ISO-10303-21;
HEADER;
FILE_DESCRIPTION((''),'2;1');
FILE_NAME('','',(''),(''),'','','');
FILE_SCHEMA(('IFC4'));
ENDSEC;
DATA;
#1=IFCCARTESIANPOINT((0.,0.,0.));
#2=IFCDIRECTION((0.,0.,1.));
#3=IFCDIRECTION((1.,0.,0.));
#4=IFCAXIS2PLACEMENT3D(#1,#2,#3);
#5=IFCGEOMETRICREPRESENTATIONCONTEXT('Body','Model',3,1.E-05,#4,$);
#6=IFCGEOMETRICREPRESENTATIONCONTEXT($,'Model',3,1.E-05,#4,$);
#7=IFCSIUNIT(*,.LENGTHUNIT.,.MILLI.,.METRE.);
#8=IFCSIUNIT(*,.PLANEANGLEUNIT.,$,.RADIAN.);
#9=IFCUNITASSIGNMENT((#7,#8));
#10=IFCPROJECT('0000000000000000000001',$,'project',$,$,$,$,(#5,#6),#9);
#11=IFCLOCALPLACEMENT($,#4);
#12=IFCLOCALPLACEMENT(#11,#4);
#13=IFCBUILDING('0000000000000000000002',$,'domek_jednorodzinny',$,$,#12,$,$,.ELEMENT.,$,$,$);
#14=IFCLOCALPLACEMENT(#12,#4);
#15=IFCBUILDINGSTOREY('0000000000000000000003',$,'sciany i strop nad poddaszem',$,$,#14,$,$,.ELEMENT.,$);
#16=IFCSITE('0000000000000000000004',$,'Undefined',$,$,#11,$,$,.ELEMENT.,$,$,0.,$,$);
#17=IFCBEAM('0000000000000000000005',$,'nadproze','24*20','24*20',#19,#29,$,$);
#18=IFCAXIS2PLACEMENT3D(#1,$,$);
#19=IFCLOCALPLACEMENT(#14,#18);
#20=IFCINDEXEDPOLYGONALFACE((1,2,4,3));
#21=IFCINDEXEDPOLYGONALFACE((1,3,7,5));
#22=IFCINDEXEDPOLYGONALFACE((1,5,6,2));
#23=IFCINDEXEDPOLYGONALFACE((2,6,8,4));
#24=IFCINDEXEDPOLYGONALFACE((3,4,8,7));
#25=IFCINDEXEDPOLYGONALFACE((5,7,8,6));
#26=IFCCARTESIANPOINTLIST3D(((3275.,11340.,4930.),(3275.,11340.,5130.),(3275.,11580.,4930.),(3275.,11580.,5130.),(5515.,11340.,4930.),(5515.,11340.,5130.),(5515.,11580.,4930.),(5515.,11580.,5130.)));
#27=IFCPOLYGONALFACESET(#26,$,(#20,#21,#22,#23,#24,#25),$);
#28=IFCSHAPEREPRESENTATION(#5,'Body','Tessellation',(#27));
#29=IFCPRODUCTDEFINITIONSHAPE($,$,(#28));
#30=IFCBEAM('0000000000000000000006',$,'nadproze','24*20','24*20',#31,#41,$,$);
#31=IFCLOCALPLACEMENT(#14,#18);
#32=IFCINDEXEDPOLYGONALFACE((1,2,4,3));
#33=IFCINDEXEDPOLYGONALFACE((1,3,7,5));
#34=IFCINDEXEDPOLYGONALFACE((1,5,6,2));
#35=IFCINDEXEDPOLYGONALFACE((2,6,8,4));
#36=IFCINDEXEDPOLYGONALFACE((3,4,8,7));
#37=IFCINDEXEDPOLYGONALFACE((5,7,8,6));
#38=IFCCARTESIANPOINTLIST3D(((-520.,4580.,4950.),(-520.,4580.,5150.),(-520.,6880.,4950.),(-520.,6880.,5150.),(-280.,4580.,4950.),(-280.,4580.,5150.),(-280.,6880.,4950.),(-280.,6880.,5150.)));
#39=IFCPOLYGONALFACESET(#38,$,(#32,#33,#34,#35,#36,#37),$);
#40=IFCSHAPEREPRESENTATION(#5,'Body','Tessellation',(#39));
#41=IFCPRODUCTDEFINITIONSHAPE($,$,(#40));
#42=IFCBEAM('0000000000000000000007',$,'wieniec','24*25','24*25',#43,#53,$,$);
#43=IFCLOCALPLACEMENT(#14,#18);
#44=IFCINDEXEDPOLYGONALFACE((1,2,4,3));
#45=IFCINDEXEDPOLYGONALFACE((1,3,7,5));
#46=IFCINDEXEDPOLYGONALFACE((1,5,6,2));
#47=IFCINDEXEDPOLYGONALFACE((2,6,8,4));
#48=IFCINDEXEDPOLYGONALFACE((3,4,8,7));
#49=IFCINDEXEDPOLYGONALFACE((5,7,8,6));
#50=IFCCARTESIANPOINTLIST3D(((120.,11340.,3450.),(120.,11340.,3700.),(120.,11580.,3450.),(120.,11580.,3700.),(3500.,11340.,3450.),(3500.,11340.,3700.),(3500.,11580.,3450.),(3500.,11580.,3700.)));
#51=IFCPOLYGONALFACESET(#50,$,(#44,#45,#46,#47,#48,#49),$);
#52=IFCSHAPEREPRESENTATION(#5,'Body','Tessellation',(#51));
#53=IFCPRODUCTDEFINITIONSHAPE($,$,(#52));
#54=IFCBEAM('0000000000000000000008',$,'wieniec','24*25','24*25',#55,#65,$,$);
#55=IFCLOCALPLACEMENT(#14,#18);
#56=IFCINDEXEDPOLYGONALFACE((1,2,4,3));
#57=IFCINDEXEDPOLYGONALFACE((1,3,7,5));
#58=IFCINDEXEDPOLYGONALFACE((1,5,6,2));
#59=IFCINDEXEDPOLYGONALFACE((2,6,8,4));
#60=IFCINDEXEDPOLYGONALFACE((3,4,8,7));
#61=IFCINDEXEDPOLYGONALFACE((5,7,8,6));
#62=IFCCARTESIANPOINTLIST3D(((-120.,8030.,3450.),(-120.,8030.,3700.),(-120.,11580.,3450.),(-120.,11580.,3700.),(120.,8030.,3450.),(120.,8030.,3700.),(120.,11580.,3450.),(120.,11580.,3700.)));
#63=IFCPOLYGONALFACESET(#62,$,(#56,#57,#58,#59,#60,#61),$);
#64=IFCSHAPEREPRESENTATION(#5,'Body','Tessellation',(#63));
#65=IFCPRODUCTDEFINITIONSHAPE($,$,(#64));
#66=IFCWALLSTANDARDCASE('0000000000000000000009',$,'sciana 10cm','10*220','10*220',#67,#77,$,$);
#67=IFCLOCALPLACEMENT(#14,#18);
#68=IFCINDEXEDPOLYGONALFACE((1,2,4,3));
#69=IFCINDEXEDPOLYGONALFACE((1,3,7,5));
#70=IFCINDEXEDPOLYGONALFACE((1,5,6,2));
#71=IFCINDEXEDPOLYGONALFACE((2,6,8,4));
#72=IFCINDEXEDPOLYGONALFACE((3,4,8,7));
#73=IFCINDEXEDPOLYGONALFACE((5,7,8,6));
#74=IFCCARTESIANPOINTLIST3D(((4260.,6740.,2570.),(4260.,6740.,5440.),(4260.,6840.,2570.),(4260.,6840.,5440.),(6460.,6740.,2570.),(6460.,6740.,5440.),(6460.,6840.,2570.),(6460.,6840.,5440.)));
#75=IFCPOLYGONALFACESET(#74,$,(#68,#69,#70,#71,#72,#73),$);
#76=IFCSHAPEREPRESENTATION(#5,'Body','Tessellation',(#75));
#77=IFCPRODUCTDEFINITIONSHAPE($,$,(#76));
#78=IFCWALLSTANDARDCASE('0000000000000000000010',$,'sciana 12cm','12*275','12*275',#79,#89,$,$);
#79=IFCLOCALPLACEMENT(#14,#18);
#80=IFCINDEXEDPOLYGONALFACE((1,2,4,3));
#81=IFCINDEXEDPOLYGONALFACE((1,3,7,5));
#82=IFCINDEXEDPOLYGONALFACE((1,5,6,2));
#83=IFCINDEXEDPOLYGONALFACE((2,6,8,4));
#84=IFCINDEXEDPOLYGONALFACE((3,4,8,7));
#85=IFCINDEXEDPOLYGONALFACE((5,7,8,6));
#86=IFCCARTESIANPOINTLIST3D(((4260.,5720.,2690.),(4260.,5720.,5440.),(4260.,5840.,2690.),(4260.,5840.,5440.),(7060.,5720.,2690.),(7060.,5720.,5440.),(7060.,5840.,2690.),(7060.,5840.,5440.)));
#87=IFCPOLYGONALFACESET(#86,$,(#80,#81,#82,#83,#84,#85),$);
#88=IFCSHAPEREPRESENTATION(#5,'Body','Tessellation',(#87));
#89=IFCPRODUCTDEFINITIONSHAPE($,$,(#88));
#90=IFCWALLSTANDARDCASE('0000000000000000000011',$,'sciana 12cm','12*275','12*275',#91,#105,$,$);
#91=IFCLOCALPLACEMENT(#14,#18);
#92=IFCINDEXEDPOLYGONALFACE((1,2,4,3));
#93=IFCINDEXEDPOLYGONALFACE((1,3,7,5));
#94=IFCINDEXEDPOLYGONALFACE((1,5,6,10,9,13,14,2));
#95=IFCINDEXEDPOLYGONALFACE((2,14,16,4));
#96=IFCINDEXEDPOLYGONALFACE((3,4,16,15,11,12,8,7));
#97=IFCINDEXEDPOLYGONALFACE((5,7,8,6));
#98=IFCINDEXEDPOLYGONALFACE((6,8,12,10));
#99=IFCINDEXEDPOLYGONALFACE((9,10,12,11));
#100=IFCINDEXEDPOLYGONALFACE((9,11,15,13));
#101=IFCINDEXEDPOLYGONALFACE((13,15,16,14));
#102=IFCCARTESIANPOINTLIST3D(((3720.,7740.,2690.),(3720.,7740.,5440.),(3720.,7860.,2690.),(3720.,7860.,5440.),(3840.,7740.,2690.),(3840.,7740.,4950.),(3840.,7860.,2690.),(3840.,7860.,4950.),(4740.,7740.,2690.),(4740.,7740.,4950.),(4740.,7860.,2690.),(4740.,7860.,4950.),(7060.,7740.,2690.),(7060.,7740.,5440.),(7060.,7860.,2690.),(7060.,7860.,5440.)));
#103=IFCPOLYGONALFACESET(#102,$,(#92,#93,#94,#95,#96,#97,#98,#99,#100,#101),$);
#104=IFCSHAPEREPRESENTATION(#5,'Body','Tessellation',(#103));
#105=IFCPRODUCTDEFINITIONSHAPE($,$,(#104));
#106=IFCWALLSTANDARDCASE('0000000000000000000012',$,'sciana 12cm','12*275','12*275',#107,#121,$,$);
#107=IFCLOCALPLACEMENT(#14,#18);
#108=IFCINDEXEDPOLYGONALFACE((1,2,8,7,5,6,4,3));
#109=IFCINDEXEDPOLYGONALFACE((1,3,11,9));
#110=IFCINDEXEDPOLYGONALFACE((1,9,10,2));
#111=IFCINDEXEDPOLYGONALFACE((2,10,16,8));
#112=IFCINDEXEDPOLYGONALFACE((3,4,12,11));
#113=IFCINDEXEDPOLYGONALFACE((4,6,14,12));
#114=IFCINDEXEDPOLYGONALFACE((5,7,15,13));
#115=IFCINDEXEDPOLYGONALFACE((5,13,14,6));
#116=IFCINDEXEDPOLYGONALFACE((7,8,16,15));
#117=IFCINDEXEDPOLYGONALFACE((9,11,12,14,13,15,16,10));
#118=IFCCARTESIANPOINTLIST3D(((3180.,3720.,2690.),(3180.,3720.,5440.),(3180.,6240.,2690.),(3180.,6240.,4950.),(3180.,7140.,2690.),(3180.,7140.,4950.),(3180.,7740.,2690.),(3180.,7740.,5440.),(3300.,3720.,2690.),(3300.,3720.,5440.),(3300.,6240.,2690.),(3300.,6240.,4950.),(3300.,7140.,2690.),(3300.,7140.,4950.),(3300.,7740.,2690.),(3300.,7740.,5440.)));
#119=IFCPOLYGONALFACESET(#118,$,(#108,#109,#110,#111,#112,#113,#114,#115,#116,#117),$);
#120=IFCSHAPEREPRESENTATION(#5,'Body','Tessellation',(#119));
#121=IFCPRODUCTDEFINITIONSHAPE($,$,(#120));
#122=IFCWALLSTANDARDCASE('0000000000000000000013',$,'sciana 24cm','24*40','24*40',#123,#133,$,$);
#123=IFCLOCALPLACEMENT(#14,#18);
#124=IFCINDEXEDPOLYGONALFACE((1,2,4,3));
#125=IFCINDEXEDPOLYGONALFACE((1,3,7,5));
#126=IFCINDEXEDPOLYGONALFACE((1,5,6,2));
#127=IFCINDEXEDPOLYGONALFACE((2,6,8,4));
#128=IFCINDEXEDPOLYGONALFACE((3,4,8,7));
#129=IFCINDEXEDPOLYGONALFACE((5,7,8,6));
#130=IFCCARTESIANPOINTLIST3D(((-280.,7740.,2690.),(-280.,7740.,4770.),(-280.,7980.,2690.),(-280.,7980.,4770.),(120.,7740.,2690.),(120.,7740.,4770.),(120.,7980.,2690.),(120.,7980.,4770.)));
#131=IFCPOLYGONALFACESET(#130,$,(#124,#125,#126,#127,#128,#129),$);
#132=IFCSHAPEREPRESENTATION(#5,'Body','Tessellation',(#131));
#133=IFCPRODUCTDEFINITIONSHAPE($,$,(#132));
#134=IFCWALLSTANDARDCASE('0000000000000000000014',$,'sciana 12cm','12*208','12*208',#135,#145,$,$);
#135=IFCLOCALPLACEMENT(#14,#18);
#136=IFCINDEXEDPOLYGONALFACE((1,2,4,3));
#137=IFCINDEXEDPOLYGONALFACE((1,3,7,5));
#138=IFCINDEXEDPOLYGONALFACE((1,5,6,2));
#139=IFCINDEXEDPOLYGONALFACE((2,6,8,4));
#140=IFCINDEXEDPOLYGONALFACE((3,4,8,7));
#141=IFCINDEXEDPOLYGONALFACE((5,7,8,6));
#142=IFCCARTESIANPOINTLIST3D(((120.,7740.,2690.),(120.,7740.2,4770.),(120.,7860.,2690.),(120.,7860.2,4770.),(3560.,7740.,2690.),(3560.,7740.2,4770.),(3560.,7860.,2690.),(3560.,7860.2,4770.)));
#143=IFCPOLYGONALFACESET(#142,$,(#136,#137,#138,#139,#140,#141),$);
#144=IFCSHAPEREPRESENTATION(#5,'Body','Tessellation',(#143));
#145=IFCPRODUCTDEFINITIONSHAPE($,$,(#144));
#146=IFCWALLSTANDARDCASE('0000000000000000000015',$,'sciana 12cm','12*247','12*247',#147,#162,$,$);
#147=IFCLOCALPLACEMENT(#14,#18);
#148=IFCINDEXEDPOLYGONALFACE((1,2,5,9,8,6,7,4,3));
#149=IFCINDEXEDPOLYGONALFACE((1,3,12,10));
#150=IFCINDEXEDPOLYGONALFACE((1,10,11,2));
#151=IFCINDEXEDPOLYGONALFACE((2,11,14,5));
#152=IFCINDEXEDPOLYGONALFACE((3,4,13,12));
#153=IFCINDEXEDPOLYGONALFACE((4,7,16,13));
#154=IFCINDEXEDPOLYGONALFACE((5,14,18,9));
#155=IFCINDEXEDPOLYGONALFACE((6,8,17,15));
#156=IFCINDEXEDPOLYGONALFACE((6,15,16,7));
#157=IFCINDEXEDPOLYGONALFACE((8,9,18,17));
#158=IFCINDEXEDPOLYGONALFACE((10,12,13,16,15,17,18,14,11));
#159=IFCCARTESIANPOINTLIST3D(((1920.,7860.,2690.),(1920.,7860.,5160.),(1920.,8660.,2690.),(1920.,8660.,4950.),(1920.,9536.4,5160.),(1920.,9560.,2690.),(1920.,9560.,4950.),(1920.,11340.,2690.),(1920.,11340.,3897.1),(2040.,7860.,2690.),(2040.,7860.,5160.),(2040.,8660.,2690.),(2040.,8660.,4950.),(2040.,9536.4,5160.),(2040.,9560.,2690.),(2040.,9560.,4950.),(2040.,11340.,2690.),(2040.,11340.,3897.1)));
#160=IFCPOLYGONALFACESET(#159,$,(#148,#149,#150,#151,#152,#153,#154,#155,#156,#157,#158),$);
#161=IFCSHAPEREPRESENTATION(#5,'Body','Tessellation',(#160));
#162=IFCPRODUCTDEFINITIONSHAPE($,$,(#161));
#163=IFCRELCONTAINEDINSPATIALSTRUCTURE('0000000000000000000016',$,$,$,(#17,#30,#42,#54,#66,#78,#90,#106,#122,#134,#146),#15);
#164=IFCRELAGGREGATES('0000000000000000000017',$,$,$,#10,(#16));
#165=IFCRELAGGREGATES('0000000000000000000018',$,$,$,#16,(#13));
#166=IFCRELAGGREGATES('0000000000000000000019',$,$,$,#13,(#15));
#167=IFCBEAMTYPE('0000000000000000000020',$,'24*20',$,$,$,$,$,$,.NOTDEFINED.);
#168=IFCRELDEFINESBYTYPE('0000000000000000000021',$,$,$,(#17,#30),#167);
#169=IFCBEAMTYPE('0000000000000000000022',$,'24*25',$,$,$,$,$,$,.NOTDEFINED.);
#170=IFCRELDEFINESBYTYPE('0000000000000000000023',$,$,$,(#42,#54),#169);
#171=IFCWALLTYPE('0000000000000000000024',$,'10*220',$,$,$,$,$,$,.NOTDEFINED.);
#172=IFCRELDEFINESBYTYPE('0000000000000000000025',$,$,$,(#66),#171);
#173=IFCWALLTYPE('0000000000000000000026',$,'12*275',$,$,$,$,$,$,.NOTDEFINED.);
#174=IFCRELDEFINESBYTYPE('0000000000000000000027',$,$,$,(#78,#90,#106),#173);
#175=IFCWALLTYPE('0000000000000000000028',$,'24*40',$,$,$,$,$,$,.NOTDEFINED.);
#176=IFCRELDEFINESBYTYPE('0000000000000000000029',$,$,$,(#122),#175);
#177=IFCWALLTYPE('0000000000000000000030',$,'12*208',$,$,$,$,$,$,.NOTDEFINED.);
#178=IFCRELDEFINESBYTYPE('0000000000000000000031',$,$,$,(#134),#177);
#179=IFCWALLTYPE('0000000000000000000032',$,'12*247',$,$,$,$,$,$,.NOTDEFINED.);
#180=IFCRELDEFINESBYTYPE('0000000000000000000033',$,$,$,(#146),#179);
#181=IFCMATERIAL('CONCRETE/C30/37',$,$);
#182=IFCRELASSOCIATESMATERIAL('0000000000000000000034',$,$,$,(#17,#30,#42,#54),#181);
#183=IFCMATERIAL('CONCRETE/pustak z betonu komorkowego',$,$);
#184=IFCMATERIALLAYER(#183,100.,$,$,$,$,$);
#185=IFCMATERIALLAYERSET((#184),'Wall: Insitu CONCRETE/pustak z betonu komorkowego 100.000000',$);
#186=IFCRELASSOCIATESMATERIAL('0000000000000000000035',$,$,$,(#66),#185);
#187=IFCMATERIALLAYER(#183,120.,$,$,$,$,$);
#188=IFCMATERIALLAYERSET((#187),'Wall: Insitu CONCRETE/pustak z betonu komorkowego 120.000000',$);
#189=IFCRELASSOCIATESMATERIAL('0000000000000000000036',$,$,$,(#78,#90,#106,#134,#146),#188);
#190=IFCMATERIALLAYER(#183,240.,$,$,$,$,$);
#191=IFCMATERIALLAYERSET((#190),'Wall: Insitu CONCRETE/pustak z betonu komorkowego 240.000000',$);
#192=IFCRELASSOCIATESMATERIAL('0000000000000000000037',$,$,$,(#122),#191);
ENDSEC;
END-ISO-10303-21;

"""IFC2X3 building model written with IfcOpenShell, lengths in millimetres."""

from ifc_helpers import new_model, si_unit, frame, frame_2d, origin_with_axes, origin_2d_with_axis, place, context, project, spatial, polyline, rectangle, outline, extrude, clip, halfspace, material, layer, layer_set, layer_usage, type_object, element, save


model = new_model("IFC2X3")

# Units and contexts
model_context_1 = context("Model", 3, precision=1e-05, world=origin_with_axes(), identifier="Body")
model_context_2 = context("Model", 3, precision=1e-05, world=origin_with_axes())
ifc_project = project(units=[si_unit("LENGTHUNIT", "METRE", prefix="MILLI"), si_unit("PLANEANGLEUNIT", "RADIAN")], contexts=[model_context_1, model_context_2])

# Site, building, storey
site_placement = place(None, origin_with_axes())
site = spatial("IfcSite", under=ifc_project, at=site_placement, Name="Undefined", CompositionType="ELEMENT", RefElevation=0.0)
building_placement = place(site_placement, origin_with_axes())
building = spatial("IfcBuilding", under=site, at=building_placement, Name="domek_jednorodzinny", CompositionType="ELEMENT")
storey_placement = place(building_placement, origin_with_axes())
storey = spatial("IfcBuildingStorey", under=building, at=storey_placement, Name="sciany i strop nad poddaszem", CompositionType="ELEMENT")

# Beams
ifc_material_1 = material(Name="CONCRETE/C30/37")
beam_type_1 = type_object("IfcBeamType", Name="24*20", PredefinedType="NOTDEFINED")
beam_1_placement = place(storey_placement, frame((3275.0, 11460.0, 5030.0), z_axis=(0.0, 0.0, 1.0), x_axis=(1.0, 0.0, 0.0)))
element("IfcBeam", 1, at=beam_1_placement, inside=storey, type_object=beam_type_1, material=ifc_material_1, Name="nadproze", Description="24*20", ObjectType="24*20", context=model_context_1, shape_type="SweptSolid", body=[
    extrude(rectangle(XDim=240.0, YDim=200.0, at=origin_2d_with_axis()), frame((2240.0, 0.0, 0.0), z_axis=(-1.0, 0.0, 0.0), x_axis=(0.0, -1.0, 0.0)), (0.0, 0.0, 1.0), 2240.0),
])
beam_2_placement = place(storey_placement, frame((-400.0, 6880.0, 5050.0), z_axis=(0.0, 0.0, 1.0), x_axis=(0.0, -1.0, 0.0)))
element("IfcBeam", 2, at=beam_2_placement, inside=storey, type_object=beam_type_1, material=ifc_material_1, Name="nadproze", Description="24*20", ObjectType="24*20", context=model_context_1, shape_type="SweptSolid", body=[
    extrude(rectangle(XDim=240.0, YDim=200.0, at=origin_2d_with_axis()), frame((2300.0, 0.0, 0.0), z_axis=(-1.0, 0.0, 0.0), x_axis=(0.0, -1.0, 0.0)), (0.0, 0.0, 1.0), 2300.0),
])
beam_type_2 = type_object("IfcBeamType", Name="24*25", PredefinedType="NOTDEFINED")
beam_3_placement = place(storey_placement, frame((3500.0, 11460.0, 3575.0), z_axis=(0.0, 0.0, 1.0), x_axis=(-1.0, 0.0, 0.0)))
element("IfcBeam", 3, at=beam_3_placement, inside=storey, type_object=beam_type_2, material=ifc_material_1, Name="wieniec", Description="24*25", ObjectType="24*25", context=model_context_1, shape_type="SweptSolid", body=[
    extrude(rectangle(XDim=240.0, YDim=250.0, at=origin_2d_with_axis()), frame((3380.0, 0.0, 0.0), z_axis=(-1.0, 0.0, 0.0), x_axis=(0.0, -1.0, 0.0)), (0.0, 0.0, 1.0), 3380.0),
])
beam_4_placement = place(storey_placement, frame((0.0, 11580.0, 3575.0), z_axis=(0.0, 0.0, 1.0), x_axis=(0.0, -1.0, 0.0)))
element("IfcBeam", 4, at=beam_4_placement, inside=storey, type_object=beam_type_2, material=ifc_material_1, Name="wieniec", Description="24*25", ObjectType="24*25", context=model_context_1, shape_type="SweptSolid", body=[
    extrude(rectangle(XDim=240.0, YDim=250.0, at=origin_2d_with_axis()), frame((3550.0, 0.0, 0.0), z_axis=(-1.0, 0.0, 0.0), x_axis=(0.0, -1.0, 0.0)), (0.0, 0.0, 1.0), 3550.0),
])

# Walls
ifc_material_2 = material(Name="CONCRETE/pustak z betonu komorkowego")
ifc_layer_1 = layer(ifc_material_2, 100.0)
ifc_layer_set_1 = layer_set([ifc_layer_1], Name="Wall: Insitu CONCRETE/pustak z betonu komorkowego 100.000000")
ifc_layer_usage_1 = layer_usage(ifc_layer_set_1, "AXIS2", "POSITIVE", -50.0)
wall_type_1 = type_object("IfcWallType", Name="10*220", PredefinedType="NOTDEFINED")
wall_1_placement = place(storey_placement, frame((4260.0, 6790.0, 2570.0), z_axis=(0.0, 0.0, 1.0), x_axis=(1.0, 0.0, 0.0)))
element("IfcWallStandardCase", 5, at=wall_1_placement, inside=storey, type_object=wall_type_1, material=ifc_layer_usage_1, Name="sciana 10cm", Description="10*220", ObjectType="10*220", context=model_context_1, shape_type="SweptSolid", body=[
    extrude(rectangle(XDim=2200.0, YDim=100.0, at=frame_2d((0.0, 1100.0), x_axis=(0.0, -1.0))), frame((0.0, 0.0, 0.0), z_axis=(0.0, 0.0, 1.0), x_axis=(0.0, -1.0, 0.0)), (0.0, 0.0, 1.0), 2870.0),
])
ifc_layer_2 = layer(ifc_material_2, 120.0)
ifc_layer_set_2 = layer_set([ifc_layer_2], Name="Wall: Insitu CONCRETE/pustak z betonu komorkowego 120.000000")
ifc_layer_usage_2 = layer_usage(ifc_layer_set_2, "AXIS2", "POSITIVE", -60.0)
wall_type_2 = type_object("IfcWallType", Name="12*275", PredefinedType="NOTDEFINED")
wall_2_placement = place(storey_placement, frame((4260.0, 5780.0, 2690.0), z_axis=(0.0, 0.0, 1.0), x_axis=(1.0, 0.0, 0.0)))
element("IfcWallStandardCase", 6, at=wall_2_placement, inside=storey, type_object=wall_type_2, material=ifc_layer_usage_2, Name="sciana 12cm", Description="12*275", ObjectType="12*275", context=model_context_1, shape_type="SweptSolid", body=[
    extrude(rectangle(XDim=2800.0, YDim=120.0, at=frame_2d((0.0, 1400.0), x_axis=(0.0, -1.0))), frame((0.0, 0.0, 0.0), z_axis=(0.0, 0.0, 1.0), x_axis=(0.0, -1.0, 0.0)), (0.0, 0.0, 1.0), 2750.0),
])

# Walls, openings
ifc_layer_usage_3 = layer_usage(ifc_layer_set_2, "AXIS2", "POSITIVE", -60.0)
wall_3_placement = place(storey_placement, frame((3720.0, 7800.0, 2690.0), z_axis=(0.0, 0.0, 1.0), x_axis=(1.0, 0.0, 0.0)))
wall_3 = element("IfcWallStandardCase", 7, at=wall_3_placement, inside=storey, type_object=wall_type_2, material=ifc_layer_usage_3, Name="sciana 12cm", Description="12*275", ObjectType="12*275", context=model_context_1, shape_type="SweptSolid", body=[
    extrude(rectangle(XDim=3340.0, YDim=120.0, at=frame_2d((0.0, 1670.0), x_axis=(0.0, -1.0))), frame((0.0, 0.0, 0.0), z_axis=(0.0, 0.0, 1.0), x_axis=(0.0, -1.0, 0.0)), (0.0, 0.0, 1.0), 2750.0),
])
opening_1_placement = place(storey_placement, frame((3720.0, 7800.0, 2690.0), z_axis=(0.0, 0.0, 1.0), x_axis=(1.0, 0.0, 0.0)))
element("IfcOpeningElement", 8, at=opening_1_placement, cuts=wall_3, ObjectType="Recess", context=model_context_1, shape_type="SweptSolid", body=[
    extrude(outline(polyline([(0.0, 0.0), (520.0, 0.0), (520.0, 900.0), (0.0, 900.0), (0.0, 0.0)])), frame((1020.0, -260.0, 0.0), z_axis=(0.0, 0.0, 1.0), x_axis=(0.0, 1.0, 0.0)), (0.0, 0.0, 1.0), 2260.0),
])
ifc_layer_usage_4 = layer_usage(ifc_layer_set_2, "AXIS2", "POSITIVE", -60.0)
wall_4_placement = place(storey_placement, frame((3240.0, 3720.0, 2690.0), z_axis=(0.0, 0.0, 1.0), x_axis=(0.0, 1.0, 0.0)))
wall_4 = element("IfcWallStandardCase", 9, at=wall_4_placement, inside=storey, type_object=wall_type_2, material=ifc_layer_usage_4, Name="sciana 12cm", Description="12*275", ObjectType="12*275", context=model_context_1, shape_type="SweptSolid", body=[
    extrude(rectangle(XDim=4020.0, YDim=120.0, at=frame_2d((0.0, 2010.0), x_axis=(0.0, -1.0))), frame((0.0, 0.0, 0.0), z_axis=(0.0, 0.0, 1.0), x_axis=(0.0, -1.0, 0.0)), (0.0, 0.0, 1.0), 2750.0),
])
opening_2_placement = place(storey_placement, frame((3240.0, 3720.0, 2690.0), z_axis=(0.0, 0.0, 1.0), x_axis=(0.0, 1.0, 0.0)))
element("IfcOpeningElement", 10, at=opening_2_placement, cuts=wall_4, ObjectType="Recess", context=model_context_1, shape_type="SweptSolid", body=[
    extrude(outline(polyline([(0.0, 0.0), (520.0, 0.0), (520.0, 900.0), (0.0, 900.0), (0.0, 0.0)])), frame((2520.0, -260.0, 2260.0), z_axis=(0.000001, 0.000001, -1.0), x_axis=(0.0, 1.0, 0.0)), (0.0, 0.0, 1.0), 2260.0),
])

# Walls
ifc_layer_3 = layer(ifc_material_2, 240.0)
ifc_layer_set_3 = layer_set([ifc_layer_3], Name="Wall: Insitu CONCRETE/pustak z betonu komorkowego 240.000000")
ifc_layer_usage_5 = layer_usage(ifc_layer_set_3, "AXIS2", "POSITIVE", -120.0)
wall_type_3 = type_object("IfcWallType", Name="24*40", PredefinedType="NOTDEFINED")
wall_5_placement = place(storey_placement, frame((-280.0, 7860.0, 2690.0), z_axis=(0.0, 0.0, 1.0), x_axis=(1.0, 0.0, 0.0)))
element("IfcWallStandardCase", 11, at=wall_5_placement, inside=storey, type_object=wall_type_3, material=ifc_layer_usage_5, Name="sciana 24cm", Description="24*40", ObjectType="24*40", context=model_context_1, shape_type="SweptSolid", body=[
    extrude(rectangle(XDim=400.0, YDim=240.0, at=frame_2d((0.0, 200.0), x_axis=(0.0, -1.0))), frame((0.0, 0.0, 0.0), z_axis=(0.0, 0.0, 1.0), x_axis=(0.0, -1.0, 0.0)), (0.0, 0.0, 1.0), 2080.0),
])
ifc_layer_usage_6 = layer_usage(ifc_layer_set_2, "AXIS2", "POSITIVE", -60.0)
wall_type_4 = type_object("IfcWallType", Name="12*208", PredefinedType="NOTDEFINED")
wall_6_placement = place(storey_placement, frame((120.0, 7800.0, 2690.0), z_axis=(0.0, 0.000083, 1.0), x_axis=(1.0, 0.0, 0.0)))
element("IfcWallStandardCase", 12, at=wall_6_placement, inside=storey, type_object=wall_type_4, material=ifc_layer_usage_6, Name="sciana 12cm", Description="12*208", ObjectType="12*208", context=model_context_1, shape_type="SweptSolid", body=[
    extrude(rectangle(XDim=3440.0, YDim=120.0, at=frame_2d((0.0, 1720.0), x_axis=(0.0, -1.0))), frame((0.0, 0.0, 0.0), z_axis=(0.0, 0.0, 1.0), x_axis=(0.0, -1.0, 0.0)), (0.0, 0.0, 1.0), 2080.0),
])

# Wall, opening
ifc_layer_usage_7 = layer_usage(ifc_layer_set_2, "AXIS2", "POSITIVE", -60.0)
wall_type_5 = type_object("IfcWallType", Name="12*247", PredefinedType="NOTDEFINED")
wall_7_placement = place(storey_placement, frame((1980.0, 7860.0, 2690.0), z_axis=(0.0, 0.0, 1.0), x_axis=(0.0, 1.0, 0.0)))
wall_7 = element("IfcWallStandardCase", 13, at=wall_7_placement, inside=storey, type_object=wall_type_5, material=ifc_layer_usage_7, Name="sciana 12cm", Description="12*247", ObjectType="12*247", context=model_context_1, shape_type="Clipping", body=[
    clip(extrude(rectangle(XDim=3480.0, YDim=120.0, at=frame_2d((0.0, 1740.0), x_axis=(0.0, -1.0))), frame((0.0, 0.0, 0.0), z_axis=(0.0, 0.0, 1.0), x_axis=(0.0, -1.0, 0.0)), (0.0, 0.0, 1.0), 2470.0), halfspace(frame((5239.6, -60.0, -25.0), z_axis=(0.573578, 0.0, 0.819151), x_axis=(-0.819152, 0.0, 0.573576)), False)),
])
opening_3_placement = place(storey_placement, frame((1980.0, 7860.0, 2690.0), z_axis=(0.0, 0.0, 1.0), x_axis=(0.0, 1.0, 0.0)))
element("IfcOpeningElement", 14, at=opening_3_placement, cuts=wall_7, ObjectType="Recess", context=model_context_1, shape_type="SweptSolid", body=[
    extrude(outline(polyline([(0.0, 0.0), (360.0, 0.0), (360.0, 900.0), (0.0, 900.0), (0.0, 0.0)])), frame((800.0, -180.0, 2260.0), z_axis=(0.000001, 0.000001, -1.0), x_axis=(0.0, 1.0, 0.0)), (0.0, 0.0, 1.0), 2260.0),
])

save(model, "model.ifc")
